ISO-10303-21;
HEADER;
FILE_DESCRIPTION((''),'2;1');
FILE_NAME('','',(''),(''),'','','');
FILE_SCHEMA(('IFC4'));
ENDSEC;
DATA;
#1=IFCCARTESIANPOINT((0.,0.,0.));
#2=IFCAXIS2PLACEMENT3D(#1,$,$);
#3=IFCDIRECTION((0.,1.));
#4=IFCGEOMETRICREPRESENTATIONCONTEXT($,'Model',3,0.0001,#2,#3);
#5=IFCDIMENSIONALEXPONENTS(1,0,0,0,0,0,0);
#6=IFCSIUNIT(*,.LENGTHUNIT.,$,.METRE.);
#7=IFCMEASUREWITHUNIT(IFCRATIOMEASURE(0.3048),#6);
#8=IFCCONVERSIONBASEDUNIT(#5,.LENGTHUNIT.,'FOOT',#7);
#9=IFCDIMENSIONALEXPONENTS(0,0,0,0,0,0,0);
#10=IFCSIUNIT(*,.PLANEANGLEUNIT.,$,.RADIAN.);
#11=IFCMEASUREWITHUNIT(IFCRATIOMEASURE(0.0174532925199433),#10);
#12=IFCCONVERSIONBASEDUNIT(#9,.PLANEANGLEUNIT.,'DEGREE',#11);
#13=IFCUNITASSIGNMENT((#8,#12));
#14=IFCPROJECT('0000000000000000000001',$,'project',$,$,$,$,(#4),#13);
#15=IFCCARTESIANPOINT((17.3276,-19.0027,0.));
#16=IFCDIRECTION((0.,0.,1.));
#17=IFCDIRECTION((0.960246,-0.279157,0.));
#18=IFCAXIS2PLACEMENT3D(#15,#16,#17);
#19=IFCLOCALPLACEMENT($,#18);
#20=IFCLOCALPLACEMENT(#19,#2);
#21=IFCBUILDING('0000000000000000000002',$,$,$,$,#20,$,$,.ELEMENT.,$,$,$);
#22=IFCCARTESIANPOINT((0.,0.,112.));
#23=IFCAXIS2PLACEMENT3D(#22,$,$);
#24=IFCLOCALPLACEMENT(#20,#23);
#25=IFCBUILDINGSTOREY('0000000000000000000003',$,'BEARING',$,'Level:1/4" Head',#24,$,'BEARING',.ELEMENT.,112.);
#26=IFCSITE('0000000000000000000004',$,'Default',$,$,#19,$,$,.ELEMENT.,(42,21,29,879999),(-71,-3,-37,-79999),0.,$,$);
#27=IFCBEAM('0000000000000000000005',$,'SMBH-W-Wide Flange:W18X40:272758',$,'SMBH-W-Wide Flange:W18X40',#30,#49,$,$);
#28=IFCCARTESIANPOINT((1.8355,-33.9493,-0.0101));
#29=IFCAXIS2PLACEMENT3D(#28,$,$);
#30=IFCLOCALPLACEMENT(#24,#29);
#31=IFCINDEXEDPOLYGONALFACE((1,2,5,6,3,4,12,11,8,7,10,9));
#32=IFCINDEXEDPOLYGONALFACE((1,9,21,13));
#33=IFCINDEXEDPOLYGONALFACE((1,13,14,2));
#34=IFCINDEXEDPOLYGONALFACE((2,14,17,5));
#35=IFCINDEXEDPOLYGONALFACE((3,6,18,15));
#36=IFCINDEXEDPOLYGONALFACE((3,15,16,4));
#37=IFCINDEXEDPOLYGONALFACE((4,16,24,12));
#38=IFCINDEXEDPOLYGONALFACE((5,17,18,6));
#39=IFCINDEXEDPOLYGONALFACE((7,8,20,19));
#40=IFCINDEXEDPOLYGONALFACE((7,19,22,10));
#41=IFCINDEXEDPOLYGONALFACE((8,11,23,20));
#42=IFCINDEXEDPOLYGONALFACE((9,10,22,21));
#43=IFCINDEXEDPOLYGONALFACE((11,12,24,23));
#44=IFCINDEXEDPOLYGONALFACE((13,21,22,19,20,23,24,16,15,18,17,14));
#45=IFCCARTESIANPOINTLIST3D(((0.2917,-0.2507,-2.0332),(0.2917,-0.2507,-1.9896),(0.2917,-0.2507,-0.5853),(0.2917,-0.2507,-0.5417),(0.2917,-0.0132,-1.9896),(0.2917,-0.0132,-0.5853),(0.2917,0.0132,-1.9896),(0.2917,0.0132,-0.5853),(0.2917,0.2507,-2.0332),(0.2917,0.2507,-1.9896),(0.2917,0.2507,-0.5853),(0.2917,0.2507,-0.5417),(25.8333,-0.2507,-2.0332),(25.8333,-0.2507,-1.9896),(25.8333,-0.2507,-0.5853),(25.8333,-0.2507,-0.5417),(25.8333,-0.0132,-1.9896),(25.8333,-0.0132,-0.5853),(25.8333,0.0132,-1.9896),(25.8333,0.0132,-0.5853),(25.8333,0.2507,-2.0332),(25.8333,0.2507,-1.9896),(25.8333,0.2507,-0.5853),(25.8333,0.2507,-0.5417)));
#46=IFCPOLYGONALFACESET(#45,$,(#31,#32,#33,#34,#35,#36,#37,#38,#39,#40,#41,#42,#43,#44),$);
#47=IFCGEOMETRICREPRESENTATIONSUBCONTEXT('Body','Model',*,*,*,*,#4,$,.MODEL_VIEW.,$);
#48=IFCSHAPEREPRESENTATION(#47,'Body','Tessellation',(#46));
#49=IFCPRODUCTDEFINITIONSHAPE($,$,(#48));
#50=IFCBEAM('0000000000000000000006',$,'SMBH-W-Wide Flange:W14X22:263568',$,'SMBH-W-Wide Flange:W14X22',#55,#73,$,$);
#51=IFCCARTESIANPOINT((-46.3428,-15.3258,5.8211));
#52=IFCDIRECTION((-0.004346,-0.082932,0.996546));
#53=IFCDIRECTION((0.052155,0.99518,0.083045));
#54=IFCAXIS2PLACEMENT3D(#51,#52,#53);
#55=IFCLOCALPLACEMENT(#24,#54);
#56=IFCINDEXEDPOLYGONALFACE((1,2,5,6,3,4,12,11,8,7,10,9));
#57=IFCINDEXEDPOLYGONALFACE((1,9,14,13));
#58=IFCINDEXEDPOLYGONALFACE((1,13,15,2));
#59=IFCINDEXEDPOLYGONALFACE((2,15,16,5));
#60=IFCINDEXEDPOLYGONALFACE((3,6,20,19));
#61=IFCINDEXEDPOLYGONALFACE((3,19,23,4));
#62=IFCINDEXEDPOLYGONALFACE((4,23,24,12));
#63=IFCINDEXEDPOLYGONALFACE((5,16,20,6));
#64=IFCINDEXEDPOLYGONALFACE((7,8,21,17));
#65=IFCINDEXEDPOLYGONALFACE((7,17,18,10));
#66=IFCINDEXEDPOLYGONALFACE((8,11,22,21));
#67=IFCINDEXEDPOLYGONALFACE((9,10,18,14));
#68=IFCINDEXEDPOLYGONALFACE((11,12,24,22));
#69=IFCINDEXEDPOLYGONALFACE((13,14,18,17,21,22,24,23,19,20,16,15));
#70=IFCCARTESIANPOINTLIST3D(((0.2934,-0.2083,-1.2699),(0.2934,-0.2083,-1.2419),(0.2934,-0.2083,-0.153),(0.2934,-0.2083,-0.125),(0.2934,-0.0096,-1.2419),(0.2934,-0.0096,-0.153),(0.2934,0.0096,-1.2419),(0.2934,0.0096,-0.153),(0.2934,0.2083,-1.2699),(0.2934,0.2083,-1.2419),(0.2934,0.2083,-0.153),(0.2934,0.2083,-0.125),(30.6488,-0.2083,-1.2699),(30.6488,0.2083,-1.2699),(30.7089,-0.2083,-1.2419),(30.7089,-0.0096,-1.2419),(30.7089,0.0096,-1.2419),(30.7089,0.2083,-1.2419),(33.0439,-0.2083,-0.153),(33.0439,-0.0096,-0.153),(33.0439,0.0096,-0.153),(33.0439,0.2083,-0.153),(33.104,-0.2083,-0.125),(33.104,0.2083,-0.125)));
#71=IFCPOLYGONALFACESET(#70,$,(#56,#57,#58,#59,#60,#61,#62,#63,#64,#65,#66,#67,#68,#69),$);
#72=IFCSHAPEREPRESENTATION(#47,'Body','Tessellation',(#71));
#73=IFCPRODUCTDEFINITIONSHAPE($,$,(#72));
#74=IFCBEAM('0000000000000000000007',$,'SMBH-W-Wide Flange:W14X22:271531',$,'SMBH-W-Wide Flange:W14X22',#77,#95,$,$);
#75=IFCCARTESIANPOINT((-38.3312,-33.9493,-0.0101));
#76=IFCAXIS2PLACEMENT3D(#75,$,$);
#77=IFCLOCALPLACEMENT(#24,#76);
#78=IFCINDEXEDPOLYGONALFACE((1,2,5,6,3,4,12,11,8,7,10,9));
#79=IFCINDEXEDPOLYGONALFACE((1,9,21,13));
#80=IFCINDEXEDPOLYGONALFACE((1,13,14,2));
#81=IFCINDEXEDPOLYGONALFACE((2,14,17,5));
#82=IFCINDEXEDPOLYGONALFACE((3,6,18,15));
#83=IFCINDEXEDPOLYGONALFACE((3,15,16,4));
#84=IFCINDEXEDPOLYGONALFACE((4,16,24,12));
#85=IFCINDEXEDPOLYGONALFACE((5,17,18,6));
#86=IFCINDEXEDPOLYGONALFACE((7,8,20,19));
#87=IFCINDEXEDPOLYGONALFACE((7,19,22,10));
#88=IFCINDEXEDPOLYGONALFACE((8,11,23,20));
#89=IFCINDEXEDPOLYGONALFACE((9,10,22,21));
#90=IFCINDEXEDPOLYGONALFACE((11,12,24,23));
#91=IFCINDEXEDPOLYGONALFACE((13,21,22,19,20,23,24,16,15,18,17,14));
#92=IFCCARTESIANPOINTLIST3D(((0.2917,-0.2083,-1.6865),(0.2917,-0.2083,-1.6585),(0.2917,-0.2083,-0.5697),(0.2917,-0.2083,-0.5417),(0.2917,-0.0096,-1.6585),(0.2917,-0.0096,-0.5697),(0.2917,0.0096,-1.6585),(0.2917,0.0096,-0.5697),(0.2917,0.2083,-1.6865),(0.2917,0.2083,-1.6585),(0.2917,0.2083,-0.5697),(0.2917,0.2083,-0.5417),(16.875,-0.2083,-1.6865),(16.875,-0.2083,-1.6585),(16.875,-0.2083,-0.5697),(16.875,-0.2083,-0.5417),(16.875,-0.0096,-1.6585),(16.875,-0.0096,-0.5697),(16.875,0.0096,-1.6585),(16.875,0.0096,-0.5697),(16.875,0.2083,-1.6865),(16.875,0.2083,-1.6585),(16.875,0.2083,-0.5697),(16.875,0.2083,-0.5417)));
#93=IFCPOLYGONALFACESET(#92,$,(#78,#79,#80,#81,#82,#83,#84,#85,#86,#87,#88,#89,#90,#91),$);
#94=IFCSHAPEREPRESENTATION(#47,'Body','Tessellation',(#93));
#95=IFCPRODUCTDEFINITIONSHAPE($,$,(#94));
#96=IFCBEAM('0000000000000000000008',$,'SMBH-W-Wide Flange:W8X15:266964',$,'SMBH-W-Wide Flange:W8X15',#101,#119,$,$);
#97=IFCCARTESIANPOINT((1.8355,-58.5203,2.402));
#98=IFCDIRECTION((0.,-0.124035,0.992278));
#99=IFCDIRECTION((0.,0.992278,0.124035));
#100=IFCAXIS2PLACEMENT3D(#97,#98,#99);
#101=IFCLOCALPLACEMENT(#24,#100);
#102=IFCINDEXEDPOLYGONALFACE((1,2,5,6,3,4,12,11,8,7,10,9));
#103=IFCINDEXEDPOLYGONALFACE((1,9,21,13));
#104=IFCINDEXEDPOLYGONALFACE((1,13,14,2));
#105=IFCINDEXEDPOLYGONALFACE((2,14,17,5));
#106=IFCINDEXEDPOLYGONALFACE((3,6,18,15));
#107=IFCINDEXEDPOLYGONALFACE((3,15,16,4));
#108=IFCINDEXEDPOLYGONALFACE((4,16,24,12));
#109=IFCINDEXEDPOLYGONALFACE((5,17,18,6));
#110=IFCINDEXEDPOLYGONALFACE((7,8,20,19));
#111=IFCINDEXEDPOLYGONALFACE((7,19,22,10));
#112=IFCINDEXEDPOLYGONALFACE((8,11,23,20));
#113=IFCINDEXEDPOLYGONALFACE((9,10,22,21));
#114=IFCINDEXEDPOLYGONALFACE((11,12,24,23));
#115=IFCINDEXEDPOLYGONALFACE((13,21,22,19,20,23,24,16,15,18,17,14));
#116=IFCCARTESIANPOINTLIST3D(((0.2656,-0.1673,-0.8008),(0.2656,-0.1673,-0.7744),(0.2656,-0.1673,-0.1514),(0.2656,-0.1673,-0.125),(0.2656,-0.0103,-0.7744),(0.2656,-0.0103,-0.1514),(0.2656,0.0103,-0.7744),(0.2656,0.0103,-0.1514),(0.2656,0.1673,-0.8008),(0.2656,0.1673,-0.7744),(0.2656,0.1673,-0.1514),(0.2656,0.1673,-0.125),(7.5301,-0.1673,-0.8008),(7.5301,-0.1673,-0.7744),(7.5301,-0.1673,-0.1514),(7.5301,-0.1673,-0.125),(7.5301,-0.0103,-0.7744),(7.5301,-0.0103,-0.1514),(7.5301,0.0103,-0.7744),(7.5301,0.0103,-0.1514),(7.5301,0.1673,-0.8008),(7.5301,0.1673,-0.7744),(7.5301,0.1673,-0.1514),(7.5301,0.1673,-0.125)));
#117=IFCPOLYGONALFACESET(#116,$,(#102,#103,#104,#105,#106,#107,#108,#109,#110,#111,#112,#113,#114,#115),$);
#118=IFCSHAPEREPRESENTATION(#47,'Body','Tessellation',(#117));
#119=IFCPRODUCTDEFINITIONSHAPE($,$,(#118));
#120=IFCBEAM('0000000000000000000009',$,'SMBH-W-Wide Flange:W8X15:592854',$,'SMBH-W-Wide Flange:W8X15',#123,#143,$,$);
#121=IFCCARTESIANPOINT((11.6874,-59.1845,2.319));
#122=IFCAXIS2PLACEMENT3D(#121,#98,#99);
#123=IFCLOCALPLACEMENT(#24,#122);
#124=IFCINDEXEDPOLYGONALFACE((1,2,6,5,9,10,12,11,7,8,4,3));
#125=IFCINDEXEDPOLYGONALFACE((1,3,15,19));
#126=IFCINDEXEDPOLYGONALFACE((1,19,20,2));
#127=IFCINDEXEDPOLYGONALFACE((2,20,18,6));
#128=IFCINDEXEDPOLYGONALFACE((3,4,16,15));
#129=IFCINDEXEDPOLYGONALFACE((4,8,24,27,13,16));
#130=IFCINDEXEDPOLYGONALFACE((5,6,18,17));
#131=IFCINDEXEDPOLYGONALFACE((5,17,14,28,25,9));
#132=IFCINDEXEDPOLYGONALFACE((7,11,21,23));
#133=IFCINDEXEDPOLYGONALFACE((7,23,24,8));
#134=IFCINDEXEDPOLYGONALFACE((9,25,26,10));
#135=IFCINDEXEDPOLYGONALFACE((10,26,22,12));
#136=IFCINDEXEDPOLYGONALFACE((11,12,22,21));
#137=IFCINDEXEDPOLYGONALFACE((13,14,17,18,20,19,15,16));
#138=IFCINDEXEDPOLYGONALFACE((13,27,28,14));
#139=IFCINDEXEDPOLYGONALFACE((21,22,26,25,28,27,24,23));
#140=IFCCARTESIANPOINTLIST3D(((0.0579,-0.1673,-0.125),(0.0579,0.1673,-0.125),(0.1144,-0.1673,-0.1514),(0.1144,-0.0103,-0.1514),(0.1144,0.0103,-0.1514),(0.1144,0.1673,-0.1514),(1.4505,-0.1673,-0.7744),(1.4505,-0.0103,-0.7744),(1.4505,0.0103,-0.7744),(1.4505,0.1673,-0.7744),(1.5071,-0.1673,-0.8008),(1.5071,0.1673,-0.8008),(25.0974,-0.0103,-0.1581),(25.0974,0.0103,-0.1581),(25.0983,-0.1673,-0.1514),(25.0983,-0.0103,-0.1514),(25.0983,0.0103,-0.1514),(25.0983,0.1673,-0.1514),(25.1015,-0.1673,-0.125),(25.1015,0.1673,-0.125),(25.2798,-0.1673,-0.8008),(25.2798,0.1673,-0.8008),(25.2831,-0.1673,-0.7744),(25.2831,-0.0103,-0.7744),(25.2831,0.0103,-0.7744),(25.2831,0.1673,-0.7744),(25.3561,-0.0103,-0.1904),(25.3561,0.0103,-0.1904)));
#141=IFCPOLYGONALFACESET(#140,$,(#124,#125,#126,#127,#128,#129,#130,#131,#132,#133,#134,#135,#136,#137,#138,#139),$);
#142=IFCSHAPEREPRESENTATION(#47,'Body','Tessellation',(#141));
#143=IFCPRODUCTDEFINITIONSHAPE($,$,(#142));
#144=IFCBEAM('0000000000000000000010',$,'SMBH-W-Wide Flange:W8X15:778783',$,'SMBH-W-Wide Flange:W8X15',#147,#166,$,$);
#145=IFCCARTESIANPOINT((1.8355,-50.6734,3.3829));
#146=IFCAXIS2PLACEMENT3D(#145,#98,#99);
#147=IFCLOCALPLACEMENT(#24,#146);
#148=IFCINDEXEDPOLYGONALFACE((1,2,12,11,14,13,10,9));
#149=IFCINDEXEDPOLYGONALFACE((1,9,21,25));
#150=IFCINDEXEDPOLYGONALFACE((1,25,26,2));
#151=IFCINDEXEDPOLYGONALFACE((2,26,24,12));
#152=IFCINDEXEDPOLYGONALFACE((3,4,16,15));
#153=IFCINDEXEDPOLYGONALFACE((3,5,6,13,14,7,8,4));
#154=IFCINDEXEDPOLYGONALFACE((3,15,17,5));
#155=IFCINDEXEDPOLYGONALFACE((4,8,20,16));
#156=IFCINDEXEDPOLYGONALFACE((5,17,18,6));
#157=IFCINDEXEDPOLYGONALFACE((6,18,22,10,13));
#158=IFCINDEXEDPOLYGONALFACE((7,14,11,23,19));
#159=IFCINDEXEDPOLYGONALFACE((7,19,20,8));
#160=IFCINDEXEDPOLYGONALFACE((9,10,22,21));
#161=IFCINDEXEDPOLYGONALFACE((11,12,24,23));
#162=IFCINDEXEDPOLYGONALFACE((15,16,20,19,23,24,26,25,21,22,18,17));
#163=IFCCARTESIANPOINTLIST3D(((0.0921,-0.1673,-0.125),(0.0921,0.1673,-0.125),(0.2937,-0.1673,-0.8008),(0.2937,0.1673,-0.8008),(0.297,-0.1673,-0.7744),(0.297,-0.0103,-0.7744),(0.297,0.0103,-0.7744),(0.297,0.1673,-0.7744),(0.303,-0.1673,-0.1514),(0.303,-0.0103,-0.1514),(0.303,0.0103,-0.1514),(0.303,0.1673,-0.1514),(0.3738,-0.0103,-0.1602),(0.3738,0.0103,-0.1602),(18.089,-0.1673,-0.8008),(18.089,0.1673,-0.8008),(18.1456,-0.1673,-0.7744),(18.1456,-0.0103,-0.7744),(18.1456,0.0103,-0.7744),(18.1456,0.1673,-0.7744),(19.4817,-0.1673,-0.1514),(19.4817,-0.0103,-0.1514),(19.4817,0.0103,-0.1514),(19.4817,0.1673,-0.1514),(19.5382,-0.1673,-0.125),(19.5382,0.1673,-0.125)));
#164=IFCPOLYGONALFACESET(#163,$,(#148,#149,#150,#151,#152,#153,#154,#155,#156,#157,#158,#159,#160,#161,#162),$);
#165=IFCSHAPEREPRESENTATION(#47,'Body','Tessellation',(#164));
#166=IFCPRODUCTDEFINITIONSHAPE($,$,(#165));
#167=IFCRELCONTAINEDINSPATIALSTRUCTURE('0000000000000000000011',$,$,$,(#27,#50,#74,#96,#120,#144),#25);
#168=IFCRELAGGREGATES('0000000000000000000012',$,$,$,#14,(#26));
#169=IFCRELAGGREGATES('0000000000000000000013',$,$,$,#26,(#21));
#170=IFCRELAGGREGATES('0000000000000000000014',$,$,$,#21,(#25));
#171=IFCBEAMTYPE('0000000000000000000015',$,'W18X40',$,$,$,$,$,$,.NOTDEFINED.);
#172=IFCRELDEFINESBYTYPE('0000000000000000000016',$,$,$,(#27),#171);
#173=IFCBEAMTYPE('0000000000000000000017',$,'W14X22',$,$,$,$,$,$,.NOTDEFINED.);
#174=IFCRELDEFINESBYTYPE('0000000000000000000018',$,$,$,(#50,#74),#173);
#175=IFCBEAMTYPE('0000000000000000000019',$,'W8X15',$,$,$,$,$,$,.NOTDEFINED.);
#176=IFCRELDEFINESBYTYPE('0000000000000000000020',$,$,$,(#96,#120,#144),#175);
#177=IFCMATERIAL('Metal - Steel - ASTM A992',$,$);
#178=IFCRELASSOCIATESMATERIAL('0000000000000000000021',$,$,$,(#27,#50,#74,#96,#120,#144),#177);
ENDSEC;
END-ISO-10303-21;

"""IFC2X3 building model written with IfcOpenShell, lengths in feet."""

from ifc_helpers import new_model, entity, si_unit, converted_unit, direction, frame, frame_2d, origin, place, context, subcontext, project, spatial, polyline, i_section, extrude, clip, halfspace, bounded_halfspace, material, type_object, element, save


model = new_model("IFC2X3")

# Units and contexts
model_context = context("Model", 3, precision=0.0001, world=origin(), true_north=direction((0.0, 1.0)))
body_context = subcontext(model_context, "Body", "Model", "MODEL_VIEW")
ifc_project = project(units=[converted_unit("LENGTHUNIT", "FOOT", entity("IfcRatioMeasure", 0.3048), si_unit("LENGTHUNIT", "METRE"), dimensions=[1, 0, 0, 0, 0, 0, 0]), converted_unit("PLANEANGLEUNIT", "DEGREE", entity("IfcRatioMeasure", 0.0174532925199433), si_unit("PLANEANGLEUNIT", "RADIAN"), dimensions=[0, 0, 0, 0, 0, 0, 0])], contexts=[model_context])

# Site, building, storey
site_placement = place(None, frame((17.3276, -19.0027, 0.0), z_axis=(0.0, 0.0, 1.0), x_axis=(0.960246, -0.279157, 0.0)))
site = spatial("IfcSite", under=ifc_project, at=site_placement, Name="Default", CompositionType="ELEMENT", RefLatitude=(42, 21, 29, 879999), RefLongitude=(-71, -3, -37, -79999), RefElevation=0.0)
building_placement = place(site_placement, origin())
building = spatial("IfcBuilding", under=site, at=building_placement, CompositionType="ELEMENT")
storey_placement = place(building_placement, frame((0.0, 0.0, 112.0)))
storey = spatial("IfcBuildingStorey", under=building, at=storey_placement, Name="BEARING", ObjectType="Level:1/4\" Head", LongName="BEARING", CompositionType="ELEMENT", Elevation=112.0)

# Beams
ifc_material_1 = material(Name="Metal - Steel - ASTM A992")
beam_type_1 = type_object("IfcBeamType", Name="W18X40", PredefinedType="NOTDEFINED")
beam_1_placement = place(storey_placement, frame((1.8355, -33.9493, -0.0101)))
element("IfcBeam", 1, at=beam_1_placement, inside=storey, type_object=beam_type_1, material=ifc_material_1, Name="SMBH-W-Wide Flange:W18X40:272758", ObjectType="SMBH-W-Wide Flange:W18X40", context=body_context, shape_type="SweptSolid", body=[
    extrude(i_section(OverallWidth=0.5013, OverallDepth=1.4915, WebThickness=0.0264, FlangeThickness=0.0436, at=frame_2d((0.0, 0.0), x_axis=(0.0, 1.0))), frame((0.2917, 0.0, -1.2874), z_axis=(1.0, 0.0, 0.0), x_axis=(0.0, 0.0, -1.0)), (0.0, 0.0, 1.0), 25.5417),
])
beam_type_2 = type_object("IfcBeamType", Name="W14X22", PredefinedType="NOTDEFINED")
beam_2_placement = place(storey_placement, frame((-46.3428, -15.3258, 5.8211), z_axis=(-0.004346, -0.082932, 0.996546), x_axis=(0.052155, 0.99518, 0.083045)))
element("IfcBeam", 2, at=beam_2_placement, inside=storey, type_object=beam_type_2, material=ifc_material_1, Name="SMBH-W-Wide Flange:W14X22:263568", ObjectType="SMBH-W-Wide Flange:W14X22", context=body_context, shape_type="SweptSolid", body=[
    clip(extrude(i_section(OverallWidth=0.4167, OverallDepth=1.1449, WebThickness=0.0192, FlangeThickness=0.028, at=frame_2d((0.0, 0.0), x_axis=(0.0, 1.0))), frame((0.2934, 0.0, -0.6974), z_axis=(1.0, 0.0, 0.0), x_axis=(0.0, 0.0, -1.0)), (0.0, 0.0, 1.0), 32.8106), halfspace(frame((33.104, -33.1577, -0.125), z_axis=(0.422622, 0.0, -0.906306), x_axis=(0.0, 1.0, 0.0)), False)),
])
beam_3_placement = place(storey_placement, frame((-38.3312, -33.9493, -0.0101)))
element("IfcBeam", 3, at=beam_3_placement, inside=storey, type_object=beam_type_2, material=ifc_material_1, Name="SMBH-W-Wide Flange:W14X22:271531", ObjectType="SMBH-W-Wide Flange:W14X22", context=body_context, shape_type="SweptSolid", body=[
    extrude(i_section(OverallWidth=0.4167, OverallDepth=1.1449, WebThickness=0.0192, FlangeThickness=0.028, at=frame_2d((0.0, 0.0), x_axis=(0.0, 1.0))), frame((0.2917, 0.0, -1.1141), z_axis=(1.0, 0.0, 0.0), x_axis=(0.0, 0.0, -1.0)), (0.0, 0.0, 1.0), 16.5833),
])
beam_type_3 = type_object("IfcBeamType", Name="W8X15", PredefinedType="NOTDEFINED")
beam_4_placement = place(storey_placement, frame((1.8355, -58.5203, 2.402), z_axis=(0.0, -0.124035, 0.992278), x_axis=(0.0, 0.992278, 0.124035)))
element("IfcBeam", 4, at=beam_4_placement, inside=storey, type_object=beam_type_3, material=ifc_material_1, Name="SMBH-W-Wide Flange:W8X15:266964", ObjectType="SMBH-W-Wide Flange:W8X15", context=body_context, shape_type="SweptSolid", body=[
    extrude(i_section(OverallWidth=0.3346, OverallDepth=0.6758, WebThickness=0.0205, FlangeThickness=0.0264, at=frame_2d((0.0, 0.0), x_axis=(0.0, 1.0))), frame((0.2656, 0.0, -0.4629), z_axis=(1.0, 0.0, 0.0), x_axis=(0.0, 0.0, -1.0)), (0.0, 0.0, 1.0), 7.2646),
])
beam_5_placement = place(storey_placement, frame((11.6874, -59.1845, 2.319), z_axis=(0.0, -0.124035, 0.992278), x_axis=(0.0, 0.992278, 0.124035)))
element("IfcBeam", 5, at=beam_5_placement, inside=storey, type_object=beam_type_3, material=ifc_material_1, Name="SMBH-W-Wide Flange:W8X15:592854", ObjectType="SMBH-W-Wide Flange:W8X15", context=body_context, shape_type="SweptSolid", body=[
    clip(clip(clip(clip(extrude(i_section(OverallWidth=0.3346, OverallDepth=0.6758, WebThickness=0.0205, FlangeThickness=0.0264, at=frame_2d((0.0, 0.0), x_axis=(0.0, 1.0))), frame((0.0579, 0.0, -0.4629), z_axis=(1.0, 0.0, 0.0), x_axis=(0.0, 0.0, -1.0)), (0.0, 0.0, 1.0), 25.2983), halfspace(frame((0.0579, 25.3738, -0.125), z_axis=(-0.422618, 0.0, -0.906308), x_axis=(0.0, -1.0, 0.0)), False)), bounded_halfspace(frame((25.248, 9.6019, -1.0554), z_axis=(0.992278, 0.0, -0.124035), x_axis=(0.0, -1.0, 0.0)), False, frame((0.0579, 0.0, -0.4629), z_axis=(1.0, 0.0, 0.0), x_axis=(0.0, 0.0, -1.0)), polyline([(-0.2725, 0.0103), (-0.2725, -0.0103), (0.3115, -0.0103), (0.3115, -0.1673), (0.3379, -0.1673), (0.3379, 0.1673), (0.3115, 0.1673), (0.3115, 0.0103), (-0.2725, 0.0103)]))), bounded_halfspace(frame((25.0974, 9.6019, -0.1581), z_axis=(0.992278, 0.0, -0.124035), x_axis=(0.0, -1.0, 0.0)), False, frame((0.0579, 0.0, -0.4629), z_axis=(1.0, 0.0, 0.0), x_axis=(0.0, 0.0, -1.0)), polyline([(-0.3048, -0.0103), (-0.3048, 0.0103), (-0.3115, 0.0103), (-0.3115, 0.1673), (-0.3379, 0.1673), (-0.3379, -0.1673), (-0.3115, -0.1673), (-0.3115, -0.0103), (-0.3048, -0.0103)]))), bounded_halfspace(frame((25.3561, 9.6019, -0.1904), z_axis=(0.124035, 0.0, 0.992278), x_axis=(0.0, -1.0, 0.0)), False, frame((0.0579, 0.0, -0.4629), z_axis=(1.0, 0.0, 0.0), x_axis=(0.0, 0.0, -1.0)), polyline([(-0.2725, -0.0103), (-0.2725, 0.0103), (-0.3048, 0.0103), (-0.3048, -0.0103), (-0.2725, -0.0103)]))),
])
beam_6_placement = place(storey_placement, frame((1.8355, -50.6734, 3.3829), z_axis=(0.0, -0.124035, 0.992278), x_axis=(0.0, 0.992278, 0.124035)))
element("IfcBeam", 6, at=beam_6_placement, inside=storey, type_object=beam_type_3, material=ifc_material_1, Name="SMBH-W-Wide Flange:W8X15:778783", ObjectType="SMBH-W-Wide Flange:W8X15", context=body_context, shape_type="SweptSolid", body=[
    clip(clip(clip(extrude(i_section(OverallWidth=0.3346, OverallDepth=0.6758, WebThickness=0.0205, FlangeThickness=0.0264, at=frame_2d((0.0, 0.0), x_axis=(0.0, 1.0))), frame((0.0921, 0.0, -0.4629), z_axis=(1.0, 0.0, 0.0), x_axis=(0.0, 0.0, -1.0)), (0.0, 0.0, 1.0), 19.4462), halfspace(frame((18.089, 19.5793, -0.8008), z_axis=(0.422618, 0.0, -0.906308), x_axis=(0.0, -1.0, 0.0)), False)), bounded_halfspace(frame((0.043, 0.0, -0.1189), z_axis=(-0.124035, 0.0, -0.992278), x_axis=(0.0, -1.0, 0.0)), False, frame((0.0921, 0.0, -0.4629), z_axis=(1.0, 0.0, 0.0), x_axis=(0.0, 0.0, -1.0)), polyline([(-0.3027, 0.0103), (-0.3027, -0.0103), (-0.3115, -0.0103), (-0.3115, -0.1673), (-0.3379, -0.1673), (-0.3379, 0.1673), (-0.3115, 0.1673), (-0.3115, 0.0103), (-0.3027, 0.0103)]))), bounded_halfspace(frame((-1.5254, 0.3333, -15.3539), z_axis=(-0.992278, 0.0, 0.124035), x_axis=(0.124035, 0.0, 0.992278)), False, frame((0.0921, 0.0, -0.4629), z_axis=(1.0, 0.0, 0.0), x_axis=(0.0, 0.0, -1.0)), polyline([(-0.3027, -0.0103), (-0.3027, 0.0103), (0.3115, 0.0103), (0.3115, 0.1673), (0.3379, 0.1673), (0.3379, -0.1673), (0.3115, -0.1673), (0.3115, -0.0103), (-0.3027, -0.0103)]))),
])

save(model, "model.ifc")
